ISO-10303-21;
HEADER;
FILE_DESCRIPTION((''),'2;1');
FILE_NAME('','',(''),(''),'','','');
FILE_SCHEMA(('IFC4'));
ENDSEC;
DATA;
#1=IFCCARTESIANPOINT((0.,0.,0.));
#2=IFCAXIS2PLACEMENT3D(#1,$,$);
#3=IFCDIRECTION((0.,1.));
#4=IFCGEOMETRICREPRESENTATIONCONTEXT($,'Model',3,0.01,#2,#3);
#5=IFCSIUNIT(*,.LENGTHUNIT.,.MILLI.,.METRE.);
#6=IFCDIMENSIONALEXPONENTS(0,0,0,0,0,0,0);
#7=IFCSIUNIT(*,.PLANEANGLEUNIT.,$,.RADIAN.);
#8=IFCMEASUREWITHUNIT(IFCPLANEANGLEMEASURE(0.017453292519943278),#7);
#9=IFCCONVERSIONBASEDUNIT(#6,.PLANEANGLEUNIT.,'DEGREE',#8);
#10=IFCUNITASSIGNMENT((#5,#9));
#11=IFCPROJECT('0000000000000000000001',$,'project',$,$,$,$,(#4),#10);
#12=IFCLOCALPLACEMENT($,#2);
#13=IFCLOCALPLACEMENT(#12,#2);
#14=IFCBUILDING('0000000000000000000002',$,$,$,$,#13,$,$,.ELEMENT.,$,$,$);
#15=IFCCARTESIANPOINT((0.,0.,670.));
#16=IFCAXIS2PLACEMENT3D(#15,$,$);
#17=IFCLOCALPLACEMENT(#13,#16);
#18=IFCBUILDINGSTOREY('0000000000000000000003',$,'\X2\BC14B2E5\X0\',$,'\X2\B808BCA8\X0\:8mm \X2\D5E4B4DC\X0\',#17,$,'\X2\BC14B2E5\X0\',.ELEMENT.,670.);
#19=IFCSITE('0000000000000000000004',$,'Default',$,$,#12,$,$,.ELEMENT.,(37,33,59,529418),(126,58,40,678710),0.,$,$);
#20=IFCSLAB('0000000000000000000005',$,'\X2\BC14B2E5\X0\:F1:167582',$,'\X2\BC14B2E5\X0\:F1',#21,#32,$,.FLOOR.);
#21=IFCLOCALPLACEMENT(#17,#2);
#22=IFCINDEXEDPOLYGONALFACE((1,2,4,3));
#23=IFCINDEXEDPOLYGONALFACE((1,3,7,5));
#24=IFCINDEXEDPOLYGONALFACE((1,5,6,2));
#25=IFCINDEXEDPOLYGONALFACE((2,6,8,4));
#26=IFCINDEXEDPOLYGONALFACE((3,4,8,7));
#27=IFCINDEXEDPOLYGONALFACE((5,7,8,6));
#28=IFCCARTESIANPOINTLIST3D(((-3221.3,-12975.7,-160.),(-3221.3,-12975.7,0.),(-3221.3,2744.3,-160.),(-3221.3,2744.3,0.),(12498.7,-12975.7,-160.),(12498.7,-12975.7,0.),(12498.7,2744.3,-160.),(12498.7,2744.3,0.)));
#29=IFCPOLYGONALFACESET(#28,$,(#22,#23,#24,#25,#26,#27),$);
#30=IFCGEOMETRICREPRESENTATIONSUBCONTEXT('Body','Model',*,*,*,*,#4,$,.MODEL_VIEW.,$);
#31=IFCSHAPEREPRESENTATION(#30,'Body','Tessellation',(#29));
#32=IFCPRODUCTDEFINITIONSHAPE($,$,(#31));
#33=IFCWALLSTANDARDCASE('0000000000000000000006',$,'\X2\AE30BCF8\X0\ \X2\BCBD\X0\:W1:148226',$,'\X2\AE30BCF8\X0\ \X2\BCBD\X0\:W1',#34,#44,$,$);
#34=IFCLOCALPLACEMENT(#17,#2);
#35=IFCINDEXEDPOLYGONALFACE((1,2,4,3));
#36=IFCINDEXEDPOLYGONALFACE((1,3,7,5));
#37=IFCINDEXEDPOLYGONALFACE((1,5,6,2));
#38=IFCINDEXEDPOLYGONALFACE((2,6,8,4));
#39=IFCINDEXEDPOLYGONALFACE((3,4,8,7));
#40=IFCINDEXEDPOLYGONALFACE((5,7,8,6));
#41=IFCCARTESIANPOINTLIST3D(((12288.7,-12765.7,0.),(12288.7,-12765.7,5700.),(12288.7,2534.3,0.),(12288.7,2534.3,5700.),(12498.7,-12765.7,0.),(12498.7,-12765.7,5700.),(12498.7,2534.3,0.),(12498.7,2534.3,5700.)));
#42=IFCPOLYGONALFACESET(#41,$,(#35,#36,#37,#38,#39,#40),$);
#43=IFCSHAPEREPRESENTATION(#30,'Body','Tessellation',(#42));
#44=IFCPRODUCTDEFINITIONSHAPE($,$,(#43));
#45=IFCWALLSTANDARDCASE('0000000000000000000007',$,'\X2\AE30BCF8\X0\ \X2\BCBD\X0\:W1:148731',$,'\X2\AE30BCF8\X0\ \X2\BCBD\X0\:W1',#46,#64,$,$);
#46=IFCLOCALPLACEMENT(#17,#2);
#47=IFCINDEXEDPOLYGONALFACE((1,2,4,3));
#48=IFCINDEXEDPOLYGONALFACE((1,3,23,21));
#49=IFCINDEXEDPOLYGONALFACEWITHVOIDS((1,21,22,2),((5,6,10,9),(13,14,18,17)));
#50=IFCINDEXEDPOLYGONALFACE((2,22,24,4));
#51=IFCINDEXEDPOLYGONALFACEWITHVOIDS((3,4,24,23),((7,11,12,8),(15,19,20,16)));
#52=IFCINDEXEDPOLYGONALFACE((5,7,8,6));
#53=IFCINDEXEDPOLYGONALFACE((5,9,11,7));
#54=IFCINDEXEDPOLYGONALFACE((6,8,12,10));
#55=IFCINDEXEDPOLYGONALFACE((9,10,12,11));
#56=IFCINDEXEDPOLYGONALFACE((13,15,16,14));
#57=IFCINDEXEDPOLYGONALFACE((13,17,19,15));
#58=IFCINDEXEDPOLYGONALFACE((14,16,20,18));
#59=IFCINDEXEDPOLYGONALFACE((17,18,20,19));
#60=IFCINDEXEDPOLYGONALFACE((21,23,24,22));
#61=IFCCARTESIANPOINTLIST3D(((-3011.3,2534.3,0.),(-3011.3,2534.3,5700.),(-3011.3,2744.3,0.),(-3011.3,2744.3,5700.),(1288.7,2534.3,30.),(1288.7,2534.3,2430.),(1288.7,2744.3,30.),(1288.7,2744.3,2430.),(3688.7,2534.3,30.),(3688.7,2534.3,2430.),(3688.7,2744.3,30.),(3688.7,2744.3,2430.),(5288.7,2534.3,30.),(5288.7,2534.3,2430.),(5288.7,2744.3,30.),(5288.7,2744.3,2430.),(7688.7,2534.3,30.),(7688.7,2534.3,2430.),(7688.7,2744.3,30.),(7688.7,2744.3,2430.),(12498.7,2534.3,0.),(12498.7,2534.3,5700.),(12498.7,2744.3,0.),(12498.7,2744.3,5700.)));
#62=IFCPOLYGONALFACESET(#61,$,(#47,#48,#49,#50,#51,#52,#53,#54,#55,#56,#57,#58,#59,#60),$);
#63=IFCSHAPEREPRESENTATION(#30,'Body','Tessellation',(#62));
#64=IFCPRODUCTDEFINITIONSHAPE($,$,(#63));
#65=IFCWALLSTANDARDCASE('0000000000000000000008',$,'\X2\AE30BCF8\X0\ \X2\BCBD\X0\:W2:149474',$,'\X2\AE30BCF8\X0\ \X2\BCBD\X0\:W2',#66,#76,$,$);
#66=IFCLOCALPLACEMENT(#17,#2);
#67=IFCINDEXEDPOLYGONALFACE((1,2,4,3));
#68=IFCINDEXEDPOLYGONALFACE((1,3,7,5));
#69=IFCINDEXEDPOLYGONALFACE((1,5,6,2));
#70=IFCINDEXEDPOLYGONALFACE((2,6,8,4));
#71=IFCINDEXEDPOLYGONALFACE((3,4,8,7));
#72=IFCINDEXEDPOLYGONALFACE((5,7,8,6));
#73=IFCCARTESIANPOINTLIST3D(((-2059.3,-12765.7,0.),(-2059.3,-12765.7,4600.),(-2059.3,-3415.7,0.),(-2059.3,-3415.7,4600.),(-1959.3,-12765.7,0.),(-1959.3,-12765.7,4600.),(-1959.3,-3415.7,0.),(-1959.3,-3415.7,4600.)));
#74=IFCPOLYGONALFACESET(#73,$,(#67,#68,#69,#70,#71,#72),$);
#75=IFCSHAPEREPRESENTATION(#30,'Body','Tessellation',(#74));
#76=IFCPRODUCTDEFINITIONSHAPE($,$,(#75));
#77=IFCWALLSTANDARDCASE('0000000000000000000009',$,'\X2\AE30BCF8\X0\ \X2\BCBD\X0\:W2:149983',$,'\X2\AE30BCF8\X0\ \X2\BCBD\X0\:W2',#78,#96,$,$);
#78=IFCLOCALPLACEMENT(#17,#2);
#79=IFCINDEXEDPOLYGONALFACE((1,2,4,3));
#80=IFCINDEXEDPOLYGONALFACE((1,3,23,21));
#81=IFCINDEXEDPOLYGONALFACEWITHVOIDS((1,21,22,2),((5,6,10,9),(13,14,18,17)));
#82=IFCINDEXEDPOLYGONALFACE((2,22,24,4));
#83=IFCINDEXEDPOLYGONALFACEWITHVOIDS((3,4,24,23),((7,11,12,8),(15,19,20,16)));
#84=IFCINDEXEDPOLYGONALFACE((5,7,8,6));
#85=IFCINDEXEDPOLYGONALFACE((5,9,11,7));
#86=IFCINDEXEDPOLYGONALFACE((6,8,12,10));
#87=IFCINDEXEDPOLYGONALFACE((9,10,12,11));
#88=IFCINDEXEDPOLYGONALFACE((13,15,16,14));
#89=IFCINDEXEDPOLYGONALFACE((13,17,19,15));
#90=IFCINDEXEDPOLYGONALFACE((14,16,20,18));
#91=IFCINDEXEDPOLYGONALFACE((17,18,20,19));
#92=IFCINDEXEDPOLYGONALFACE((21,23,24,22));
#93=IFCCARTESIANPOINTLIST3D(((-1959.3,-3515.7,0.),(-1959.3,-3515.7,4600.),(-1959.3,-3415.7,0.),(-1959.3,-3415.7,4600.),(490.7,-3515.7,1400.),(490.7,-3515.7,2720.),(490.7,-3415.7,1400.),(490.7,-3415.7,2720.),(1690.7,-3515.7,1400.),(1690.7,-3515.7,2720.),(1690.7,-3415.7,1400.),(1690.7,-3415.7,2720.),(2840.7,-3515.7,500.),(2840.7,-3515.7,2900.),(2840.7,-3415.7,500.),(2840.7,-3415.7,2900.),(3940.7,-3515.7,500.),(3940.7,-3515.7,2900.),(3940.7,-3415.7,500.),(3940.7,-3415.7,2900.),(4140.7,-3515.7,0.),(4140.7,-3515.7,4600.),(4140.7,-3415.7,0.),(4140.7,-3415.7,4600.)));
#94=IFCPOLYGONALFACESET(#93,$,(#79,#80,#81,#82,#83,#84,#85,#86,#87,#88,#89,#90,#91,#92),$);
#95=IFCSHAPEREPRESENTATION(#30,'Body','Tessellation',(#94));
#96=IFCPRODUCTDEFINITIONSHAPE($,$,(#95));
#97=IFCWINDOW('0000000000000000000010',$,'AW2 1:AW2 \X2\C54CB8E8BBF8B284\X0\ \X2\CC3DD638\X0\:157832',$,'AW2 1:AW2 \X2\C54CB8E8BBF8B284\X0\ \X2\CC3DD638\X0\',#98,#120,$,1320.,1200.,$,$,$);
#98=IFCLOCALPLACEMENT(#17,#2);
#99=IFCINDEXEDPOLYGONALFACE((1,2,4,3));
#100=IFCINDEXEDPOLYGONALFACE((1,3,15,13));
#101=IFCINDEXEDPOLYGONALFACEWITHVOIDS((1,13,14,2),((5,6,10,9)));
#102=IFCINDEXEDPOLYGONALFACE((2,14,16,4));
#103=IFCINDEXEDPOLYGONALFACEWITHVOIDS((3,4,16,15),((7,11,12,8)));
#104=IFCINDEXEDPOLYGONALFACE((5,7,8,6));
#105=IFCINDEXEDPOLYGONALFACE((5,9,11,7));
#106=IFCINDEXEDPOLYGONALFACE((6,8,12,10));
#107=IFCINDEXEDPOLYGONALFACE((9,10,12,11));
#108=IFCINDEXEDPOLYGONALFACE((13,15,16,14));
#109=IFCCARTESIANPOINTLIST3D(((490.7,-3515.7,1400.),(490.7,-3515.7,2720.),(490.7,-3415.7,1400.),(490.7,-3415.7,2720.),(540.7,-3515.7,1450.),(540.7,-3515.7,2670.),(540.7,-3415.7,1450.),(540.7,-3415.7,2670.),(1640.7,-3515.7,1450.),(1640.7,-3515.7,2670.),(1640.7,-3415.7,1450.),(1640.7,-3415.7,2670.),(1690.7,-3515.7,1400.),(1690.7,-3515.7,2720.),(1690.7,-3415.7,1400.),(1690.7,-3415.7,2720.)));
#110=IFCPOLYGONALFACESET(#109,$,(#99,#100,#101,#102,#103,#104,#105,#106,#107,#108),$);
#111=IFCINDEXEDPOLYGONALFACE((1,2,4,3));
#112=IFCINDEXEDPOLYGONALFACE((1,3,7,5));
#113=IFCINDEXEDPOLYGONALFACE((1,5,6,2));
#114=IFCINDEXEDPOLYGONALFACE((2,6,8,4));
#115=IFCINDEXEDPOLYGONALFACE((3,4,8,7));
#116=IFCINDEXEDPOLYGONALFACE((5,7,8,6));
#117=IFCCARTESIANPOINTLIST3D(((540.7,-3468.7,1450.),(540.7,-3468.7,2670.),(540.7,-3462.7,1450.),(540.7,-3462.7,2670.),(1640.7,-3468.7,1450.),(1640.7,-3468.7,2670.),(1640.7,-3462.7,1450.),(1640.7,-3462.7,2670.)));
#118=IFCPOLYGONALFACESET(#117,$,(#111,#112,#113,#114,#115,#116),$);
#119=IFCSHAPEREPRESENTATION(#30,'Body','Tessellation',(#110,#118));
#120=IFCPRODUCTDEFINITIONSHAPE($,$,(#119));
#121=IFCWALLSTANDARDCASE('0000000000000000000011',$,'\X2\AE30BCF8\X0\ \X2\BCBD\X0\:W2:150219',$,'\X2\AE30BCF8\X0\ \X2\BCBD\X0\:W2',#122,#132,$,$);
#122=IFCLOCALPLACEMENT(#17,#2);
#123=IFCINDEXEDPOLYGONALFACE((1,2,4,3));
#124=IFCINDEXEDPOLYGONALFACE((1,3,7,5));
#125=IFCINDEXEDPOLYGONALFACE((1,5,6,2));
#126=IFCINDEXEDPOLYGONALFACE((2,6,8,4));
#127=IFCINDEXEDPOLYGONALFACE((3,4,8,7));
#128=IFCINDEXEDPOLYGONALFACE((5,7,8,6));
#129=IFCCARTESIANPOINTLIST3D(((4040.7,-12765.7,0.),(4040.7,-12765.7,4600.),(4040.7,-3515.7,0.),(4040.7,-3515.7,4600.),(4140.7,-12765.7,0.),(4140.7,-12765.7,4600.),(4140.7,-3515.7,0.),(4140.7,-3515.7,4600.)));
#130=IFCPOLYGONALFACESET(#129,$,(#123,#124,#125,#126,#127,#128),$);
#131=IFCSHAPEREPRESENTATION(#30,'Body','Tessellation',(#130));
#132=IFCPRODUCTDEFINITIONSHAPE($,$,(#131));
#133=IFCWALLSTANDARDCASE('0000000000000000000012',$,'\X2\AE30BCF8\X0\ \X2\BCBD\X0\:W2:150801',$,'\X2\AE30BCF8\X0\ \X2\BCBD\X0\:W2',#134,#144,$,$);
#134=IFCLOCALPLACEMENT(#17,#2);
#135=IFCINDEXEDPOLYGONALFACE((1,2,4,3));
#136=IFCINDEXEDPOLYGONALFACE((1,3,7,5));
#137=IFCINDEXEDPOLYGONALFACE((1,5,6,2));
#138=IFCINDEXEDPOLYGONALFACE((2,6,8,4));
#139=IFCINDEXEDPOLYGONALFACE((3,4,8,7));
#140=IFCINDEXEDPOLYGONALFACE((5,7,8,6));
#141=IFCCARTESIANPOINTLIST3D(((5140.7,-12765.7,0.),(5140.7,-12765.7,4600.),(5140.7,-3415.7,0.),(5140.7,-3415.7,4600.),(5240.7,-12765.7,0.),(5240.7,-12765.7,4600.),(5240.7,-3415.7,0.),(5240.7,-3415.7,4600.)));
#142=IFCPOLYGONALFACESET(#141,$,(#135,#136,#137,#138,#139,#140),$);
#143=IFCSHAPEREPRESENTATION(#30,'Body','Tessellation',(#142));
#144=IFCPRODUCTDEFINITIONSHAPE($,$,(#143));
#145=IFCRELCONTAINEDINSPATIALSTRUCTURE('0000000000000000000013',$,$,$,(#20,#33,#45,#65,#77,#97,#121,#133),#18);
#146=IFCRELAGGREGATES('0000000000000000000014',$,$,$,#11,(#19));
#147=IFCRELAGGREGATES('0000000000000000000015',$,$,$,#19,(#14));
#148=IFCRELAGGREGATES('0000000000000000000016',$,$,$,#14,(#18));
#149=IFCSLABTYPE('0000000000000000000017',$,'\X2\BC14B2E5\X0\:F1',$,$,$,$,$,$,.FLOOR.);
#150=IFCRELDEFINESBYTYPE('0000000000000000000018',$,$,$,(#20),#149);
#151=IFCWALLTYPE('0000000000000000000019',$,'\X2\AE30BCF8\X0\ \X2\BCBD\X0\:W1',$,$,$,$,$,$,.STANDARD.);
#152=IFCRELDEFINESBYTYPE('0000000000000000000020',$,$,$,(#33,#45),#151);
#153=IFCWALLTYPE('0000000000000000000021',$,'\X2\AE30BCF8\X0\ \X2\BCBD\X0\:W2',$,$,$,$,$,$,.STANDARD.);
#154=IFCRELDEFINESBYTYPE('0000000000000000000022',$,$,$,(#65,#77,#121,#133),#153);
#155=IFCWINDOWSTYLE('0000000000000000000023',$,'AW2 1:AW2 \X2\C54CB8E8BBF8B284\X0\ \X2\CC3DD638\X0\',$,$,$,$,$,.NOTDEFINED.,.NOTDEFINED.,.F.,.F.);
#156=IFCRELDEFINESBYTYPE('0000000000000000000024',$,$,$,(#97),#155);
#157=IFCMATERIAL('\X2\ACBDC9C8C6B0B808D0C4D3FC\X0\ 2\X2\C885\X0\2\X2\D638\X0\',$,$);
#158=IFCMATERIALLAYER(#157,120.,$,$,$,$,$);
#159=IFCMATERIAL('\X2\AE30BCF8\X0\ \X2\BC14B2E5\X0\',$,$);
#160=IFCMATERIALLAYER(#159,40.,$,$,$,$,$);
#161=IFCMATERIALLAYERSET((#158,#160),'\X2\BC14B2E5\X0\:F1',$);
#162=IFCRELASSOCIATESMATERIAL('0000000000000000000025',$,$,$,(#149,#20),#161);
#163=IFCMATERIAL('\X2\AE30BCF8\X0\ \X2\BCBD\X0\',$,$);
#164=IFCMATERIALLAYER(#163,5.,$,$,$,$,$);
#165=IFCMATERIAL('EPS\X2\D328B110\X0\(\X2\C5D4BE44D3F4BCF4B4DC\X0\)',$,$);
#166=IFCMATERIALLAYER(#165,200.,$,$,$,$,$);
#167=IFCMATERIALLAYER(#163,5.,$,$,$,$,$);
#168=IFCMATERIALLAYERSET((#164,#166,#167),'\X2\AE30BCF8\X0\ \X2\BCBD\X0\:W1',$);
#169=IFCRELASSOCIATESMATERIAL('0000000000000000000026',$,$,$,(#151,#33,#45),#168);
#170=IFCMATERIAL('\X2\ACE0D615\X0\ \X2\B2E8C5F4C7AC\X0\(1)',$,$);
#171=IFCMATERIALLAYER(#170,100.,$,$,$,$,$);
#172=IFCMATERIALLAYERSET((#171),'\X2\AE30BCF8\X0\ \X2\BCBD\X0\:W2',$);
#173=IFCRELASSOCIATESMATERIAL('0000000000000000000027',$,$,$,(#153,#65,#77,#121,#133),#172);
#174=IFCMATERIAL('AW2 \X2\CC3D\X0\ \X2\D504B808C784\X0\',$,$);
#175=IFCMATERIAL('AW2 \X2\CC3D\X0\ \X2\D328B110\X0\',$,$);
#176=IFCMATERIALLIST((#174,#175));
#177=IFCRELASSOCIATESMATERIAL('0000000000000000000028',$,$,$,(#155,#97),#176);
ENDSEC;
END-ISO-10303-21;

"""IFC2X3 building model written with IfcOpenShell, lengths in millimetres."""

from ifc_helpers import new_model, entity, si_unit, converted_unit, direction, frame, frame_2d, origin, origin_2d_with_axis, place, context, subcontext, project, spatial, polyline, rectangle, outline, extrude, source, transform, mapped, material, material_list, layer, layer_set, layer_usage, type_object, type_shapes, element, fill, save


model = new_model("IFC2X3")

# Units and contexts
model_context = context("Model", 3, precision=0.01, world=origin(), true_north=direction((0.0, 1.0)))
body_context = subcontext(model_context, "Body", "Model", "MODEL_VIEW")
ifc_project = project(units=[si_unit("LENGTHUNIT", "METRE", prefix="MILLI"), converted_unit("PLANEANGLEUNIT", "DEGREE", entity("IfcPlaneAngleMeasure", 0.017453292519943278), si_unit("PLANEANGLEUNIT", "RADIAN"), dimensions=[0, 0, 0, 0, 0, 0, 0])], contexts=[model_context])

# Site, building, storey
site_placement = place(None, origin())
site = spatial("IfcSite", under=ifc_project, at=site_placement, Name="Default", CompositionType="ELEMENT", RefLatitude=(37, 33, 59, 529418), RefLongitude=(126, 58, 40, 678710), RefElevation=0.0)
building_placement = place(site_placement, origin())
building = spatial("IfcBuilding", under=site, at=building_placement, CompositionType="ELEMENT")
storey_placement = place(building_placement, frame((0.0, 0.0, 670.0)))
storey = spatial("IfcBuildingStorey", under=building, at=storey_placement, Name="바닥", ObjectType="레벨:8mm 헤드", LongName="바닥", CompositionType="ELEMENT", Elevation=670.0)

# Slab
ifc_material_1 = material(Name="경질우레탄폼 2종2호")
ifc_layer_1 = layer(ifc_material_1, 120.0)
ifc_material_2 = material(Name="기본 바닥")
ifc_layer_2 = layer(ifc_material_2, 40.0)
ifc_layer_set_1 = layer_set([ifc_layer_1, ifc_layer_2], Name="바닥:F1")
ifc_layer_usage_1 = layer_usage(ifc_layer_set_1, "AXIS3", "POSITIVE", 0.0)
slab_type = type_object("IfcSlabType", Name="바닥:F1", PredefinedType="FLOOR", material=ifc_layer_set_1)
slab_placement = place(storey_placement, origin())
element("IfcSlab", 1, at=slab_placement, inside=storey, type_object=slab_type, material=ifc_layer_usage_1, Name="바닥:F1:167582", ObjectType="바닥:F1", PredefinedType="FLOOR", context=body_context, shape_type="SweptSolid", body=[
    extrude(rectangle(XDim=15720.0, YDim=15720.0, at=origin_2d_with_axis()), frame((4638.7, -5115.7, 0.0), z_axis=(0.0, 0.0, -1.0), x_axis=(0.0, 1.0, 0.0)), (0.0, 0.0, 1.0), 160.0),
])

# Wall
ifc_material_3 = material(Name="기본 벽")
ifc_layer_3 = layer(ifc_material_3, 5.0)
ifc_material_4 = material(Name="EPS패널(엔비폴보드)")
ifc_layer_4 = layer(ifc_material_4, 200.0)
ifc_layer_5 = layer(ifc_material_3, 5.0)
ifc_layer_set_2 = layer_set([ifc_layer_3, ifc_layer_4, ifc_layer_5], Name="기본 벽:W1")
ifc_layer_usage_2 = layer_usage(ifc_layer_set_2, "AXIS2", "NEGATIVE", 105.0)
wall_type_1 = type_object("IfcWallType", Name="기본 벽:W1", PredefinedType="STANDARD", material=ifc_layer_set_2)
wall_1_placement = place(storey_placement, frame((12393.7, 2534.3, 0.0), z_axis=(0.0, 0.0, 1.0), x_axis=(0.0, -1.0, 0.0)))
element("IfcWallStandardCase", 2, at=wall_1_placement, inside=storey, type_object=wall_type_1, material=ifc_layer_usage_2, Name="기본 벽:W1:148226", ObjectType="기본 벽:W1", context=body_context, shape_type="SweptSolid", body=[
    extrude(rectangle(XDim=15300.0, YDim=210.0, at=frame_2d((7650.0, 0.0), x_axis=(-1.0, 0.0))), origin(), (0.0, 0.0, 1.0), 5700.0),
])

# Wall, openings
ifc_layer_usage_3 = layer_usage(ifc_layer_set_2, "AXIS2", "NEGATIVE", 105.0)
wall_2_placement = place(storey_placement, frame((-3011.3, 2639.3, 0.0)))
wall_2 = element("IfcWallStandardCase", 3, at=wall_2_placement, inside=storey, type_object=wall_type_1, material=ifc_layer_usage_3, Name="기본 벽:W1:148731", ObjectType="기본 벽:W1", context=body_context, shape_type="SweptSolid", body=[
    extrude(rectangle(XDim=15510.0, YDim=210.0, at=frame_2d((7755.0, 0.0), x_axis=(-1.0, 0.0))), origin(), (0.0, 0.0, 1.0), 5700.0),
])
opening_1_placement = place(wall_2_placement, frame((8300.0, -105.0, 30.0)))
element("IfcOpeningElement", 4, at=opening_1_placement, cuts=wall_2, ObjectType="Opening", context=body_context, shape_type="SweptSolid", body=[
    extrude(rectangle(XDim=2400.0, YDim=2400.0, at=frame_2d((1200.0, 1200.0), x_axis=(1.0, 0.0))), frame((0.0, 0.0, 0.0), z_axis=(0.0, 1.0, 0.0), x_axis=(0.0, 0.0, 1.0)), (0.0, 0.0, 1.0), 210.0),
])
opening_2_placement = place(wall_2_placement, frame((4300.0, -105.0, 30.0)))
element("IfcOpeningElement", 5, at=opening_2_placement, cuts=wall_2, ObjectType="Opening", context=body_context, shape_type="SweptSolid", body=[
    extrude(rectangle(XDim=2400.0, YDim=2400.0, at=frame_2d((1200.0, 1200.0), x_axis=(1.0, 0.0))), frame((0.0, 0.0, 0.0), z_axis=(0.0, 1.0, 0.0), x_axis=(0.0, 0.0, 1.0)), (0.0, 0.0, 1.0), 210.0),
])

# Wall
ifc_material_5 = material(Name="고형 단열재(1)")
ifc_layer_6 = layer(ifc_material_5, 100.0)
ifc_layer_set_3 = layer_set([ifc_layer_6], Name="기본 벽:W2")
ifc_layer_usage_4 = layer_usage(ifc_layer_set_3, "AXIS2", "NEGATIVE", 50.0)
wall_type_2 = type_object("IfcWallType", Name="기본 벽:W2", PredefinedType="STANDARD", material=ifc_layer_set_3)
wall_3_placement = place(storey_placement, frame((-2009.3, -12765.7, 0.0), z_axis=(0.0, 0.0, 1.0), x_axis=(0.0, 1.0, 0.0)))
element("IfcWallStandardCase", 6, at=wall_3_placement, inside=storey, type_object=wall_type_2, material=ifc_layer_usage_4, Name="기본 벽:W2:149474", ObjectType="기본 벽:W2", context=body_context, shape_type="SweptSolid", body=[
    extrude(rectangle(XDim=9350.0, YDim=100.0, at=frame_2d((4675.0, 0.0), x_axis=(-1.0, 0.0))), origin(), (0.0, 0.0, 1.0), 4600.0),
])

# Wall, openings, window
ifc_layer_usage_5 = layer_usage(ifc_layer_set_3, "AXIS2", "NEGATIVE", 50.0)
wall_4_placement = place(storey_placement, frame((-1959.3, -3465.7, 0.0)))
wall_4 = element("IfcWallStandardCase", 7, at=wall_4_placement, inside=storey, type_object=wall_type_2, material=ifc_layer_usage_5, Name="기본 벽:W2:149983", ObjectType="기본 벽:W2", context=body_context, shape_type="SweptSolid", body=[
    extrude(rectangle(XDim=6100.0, YDim=100.0, at=frame_2d((3050.0, 0.0), x_axis=(-1.0, 0.0))), origin(), (0.0, 0.0, 1.0), 4600.0),
])
opening_3_placement = place(wall_4_placement, frame((4800.0, -50.0, 500.0)))
element("IfcOpeningElement", 8, at=opening_3_placement, cuts=wall_4, ObjectType="Opening", context=body_context, shape_type="SweptSolid", body=[
    extrude(rectangle(XDim=2400.0, YDim=1100.0, at=frame_2d((1200.0, 550.0), x_axis=(1.0, 0.0))), frame((0.0, 0.0, 0.0), z_axis=(0.0, 1.0, 0.0), x_axis=(0.0, 0.0, 1.0)), (0.0, 0.0, 1.0), 100.0),
])
opening_4_placement = place(wall_4_placement, frame((2450.0, -50.0, 1400.0)))
opening_4 = element("IfcOpeningElement", 9, at=opening_4_placement, cuts=wall_4, ObjectType="Opening", context=body_context, shape_type="SweptSolid", body=[
    extrude(rectangle(XDim=1320.0, YDim=1200.0, at=frame_2d((660.0, 600.0), x_axis=(1.0, 0.0))), frame((0.0, 0.0, 0.0), z_axis=(0.0, 1.0, 0.0), x_axis=(0.0, 0.0, 1.0)), (0.0, 0.0, 1.0), 100.0),
])
ifc_material_6 = material(Name="AW2 창 프레임")
ifc_material_7 = material(Name="AW2 창 패널")
ifc_material_list = material_list([ifc_material_6, ifc_material_7])
window_style = type_object("IfcWindowStyle", Name="AW2 1:AW2 알루미늄 창호", ConstructionType="NOTDEFINED", OperationType="NOTDEFINED", ParameterTakesPrecedence=False, Sizeable=False, material=ifc_material_list)
shared_shape = source(origin(), body_context, "Body", "SweptSolid", [
    extrude(outline(polyline([(-600.0, -660.0), (600.0, -660.0), (600.0, 660.0), (-600.0, 660.0), (-600.0, -660.0)]), holes=[polyline([(-550.0, -610.0), (-550.0, 610.0), (550.0, 610.0), (550.0, -610.0), (-550.0, -610.0)])]), frame((600.0, 0.0, 660.0), z_axis=(0.0, 1.0, 0.0), x_axis=(1.0, 0.0, 0.0)), (0.0, 0.0, 1.0), 100.0),
    extrude(rectangle(XDim=6.0, YDim=1100.0, at=origin_2d_with_axis()), frame((600.0, 50.0, 50.0), z_axis=(0.0, 0.0, 1.0), x_axis=(0.0, -1.0, 0.0)), (0.0, 0.0, 1.0), 1220.0),
])
type_shapes(window_style, [shared_shape])
window_1_placement = place(opening_4_placement, origin())
window_1 = element("IfcWindow", 10, at=window_1_placement, inside=storey, type_object=window_style, material=ifc_material_list, Name="AW2 1:AW2 알루미늄 창호:157832", ObjectType="AW2 1:AW2 알루미늄 창호", OverallHeight=1320.0, OverallWidth=1200.0, context=body_context, shape_type="MappedRepresentation", body=[
    mapped(shared_shape, transform((0.0, 0.0, 0.0), scale=1.0)),
])
fill(opening_4, window_1)

# Walls
ifc_layer_usage_6 = layer_usage(ifc_layer_set_3, "AXIS2", "NEGATIVE", 50.0)
wall_5_placement = place(storey_placement, frame((4090.7, -3515.7, 0.0), z_axis=(0.0, 0.0, 1.0), x_axis=(0.0, -1.0, 0.0)))
element("IfcWallStandardCase", 11, at=wall_5_placement, inside=storey, type_object=wall_type_2, material=ifc_layer_usage_6, Name="기본 벽:W2:150219", ObjectType="기본 벽:W2", context=body_context, shape_type="SweptSolid", body=[
    extrude(rectangle(XDim=9250.0, YDim=100.0, at=frame_2d((4625.0, 0.0), x_axis=(-1.0, 0.0))), origin(), (0.0, 0.0, 1.0), 4600.0),
])
ifc_layer_usage_7 = layer_usage(ifc_layer_set_3, "AXIS2", "NEGATIVE", 50.0)
wall_6_placement = place(storey_placement, frame((5190.7, -12765.7, 0.0), z_axis=(0.0, 0.0, 1.0), x_axis=(0.0, 1.0, 0.0)))
element("IfcWallStandardCase", 12, at=wall_6_placement, inside=storey, type_object=wall_type_2, material=ifc_layer_usage_7, Name="기본 벽:W2:150801", ObjectType="기본 벽:W2", context=body_context, shape_type="SweptSolid", body=[
    extrude(rectangle(XDim=9350.0, YDim=100.0, at=frame_2d((4675.0, 0.0), x_axis=(-1.0, 0.0))), origin(), (0.0, 0.0, 1.0), 4600.0),
])

save(model, "model.ifc")
